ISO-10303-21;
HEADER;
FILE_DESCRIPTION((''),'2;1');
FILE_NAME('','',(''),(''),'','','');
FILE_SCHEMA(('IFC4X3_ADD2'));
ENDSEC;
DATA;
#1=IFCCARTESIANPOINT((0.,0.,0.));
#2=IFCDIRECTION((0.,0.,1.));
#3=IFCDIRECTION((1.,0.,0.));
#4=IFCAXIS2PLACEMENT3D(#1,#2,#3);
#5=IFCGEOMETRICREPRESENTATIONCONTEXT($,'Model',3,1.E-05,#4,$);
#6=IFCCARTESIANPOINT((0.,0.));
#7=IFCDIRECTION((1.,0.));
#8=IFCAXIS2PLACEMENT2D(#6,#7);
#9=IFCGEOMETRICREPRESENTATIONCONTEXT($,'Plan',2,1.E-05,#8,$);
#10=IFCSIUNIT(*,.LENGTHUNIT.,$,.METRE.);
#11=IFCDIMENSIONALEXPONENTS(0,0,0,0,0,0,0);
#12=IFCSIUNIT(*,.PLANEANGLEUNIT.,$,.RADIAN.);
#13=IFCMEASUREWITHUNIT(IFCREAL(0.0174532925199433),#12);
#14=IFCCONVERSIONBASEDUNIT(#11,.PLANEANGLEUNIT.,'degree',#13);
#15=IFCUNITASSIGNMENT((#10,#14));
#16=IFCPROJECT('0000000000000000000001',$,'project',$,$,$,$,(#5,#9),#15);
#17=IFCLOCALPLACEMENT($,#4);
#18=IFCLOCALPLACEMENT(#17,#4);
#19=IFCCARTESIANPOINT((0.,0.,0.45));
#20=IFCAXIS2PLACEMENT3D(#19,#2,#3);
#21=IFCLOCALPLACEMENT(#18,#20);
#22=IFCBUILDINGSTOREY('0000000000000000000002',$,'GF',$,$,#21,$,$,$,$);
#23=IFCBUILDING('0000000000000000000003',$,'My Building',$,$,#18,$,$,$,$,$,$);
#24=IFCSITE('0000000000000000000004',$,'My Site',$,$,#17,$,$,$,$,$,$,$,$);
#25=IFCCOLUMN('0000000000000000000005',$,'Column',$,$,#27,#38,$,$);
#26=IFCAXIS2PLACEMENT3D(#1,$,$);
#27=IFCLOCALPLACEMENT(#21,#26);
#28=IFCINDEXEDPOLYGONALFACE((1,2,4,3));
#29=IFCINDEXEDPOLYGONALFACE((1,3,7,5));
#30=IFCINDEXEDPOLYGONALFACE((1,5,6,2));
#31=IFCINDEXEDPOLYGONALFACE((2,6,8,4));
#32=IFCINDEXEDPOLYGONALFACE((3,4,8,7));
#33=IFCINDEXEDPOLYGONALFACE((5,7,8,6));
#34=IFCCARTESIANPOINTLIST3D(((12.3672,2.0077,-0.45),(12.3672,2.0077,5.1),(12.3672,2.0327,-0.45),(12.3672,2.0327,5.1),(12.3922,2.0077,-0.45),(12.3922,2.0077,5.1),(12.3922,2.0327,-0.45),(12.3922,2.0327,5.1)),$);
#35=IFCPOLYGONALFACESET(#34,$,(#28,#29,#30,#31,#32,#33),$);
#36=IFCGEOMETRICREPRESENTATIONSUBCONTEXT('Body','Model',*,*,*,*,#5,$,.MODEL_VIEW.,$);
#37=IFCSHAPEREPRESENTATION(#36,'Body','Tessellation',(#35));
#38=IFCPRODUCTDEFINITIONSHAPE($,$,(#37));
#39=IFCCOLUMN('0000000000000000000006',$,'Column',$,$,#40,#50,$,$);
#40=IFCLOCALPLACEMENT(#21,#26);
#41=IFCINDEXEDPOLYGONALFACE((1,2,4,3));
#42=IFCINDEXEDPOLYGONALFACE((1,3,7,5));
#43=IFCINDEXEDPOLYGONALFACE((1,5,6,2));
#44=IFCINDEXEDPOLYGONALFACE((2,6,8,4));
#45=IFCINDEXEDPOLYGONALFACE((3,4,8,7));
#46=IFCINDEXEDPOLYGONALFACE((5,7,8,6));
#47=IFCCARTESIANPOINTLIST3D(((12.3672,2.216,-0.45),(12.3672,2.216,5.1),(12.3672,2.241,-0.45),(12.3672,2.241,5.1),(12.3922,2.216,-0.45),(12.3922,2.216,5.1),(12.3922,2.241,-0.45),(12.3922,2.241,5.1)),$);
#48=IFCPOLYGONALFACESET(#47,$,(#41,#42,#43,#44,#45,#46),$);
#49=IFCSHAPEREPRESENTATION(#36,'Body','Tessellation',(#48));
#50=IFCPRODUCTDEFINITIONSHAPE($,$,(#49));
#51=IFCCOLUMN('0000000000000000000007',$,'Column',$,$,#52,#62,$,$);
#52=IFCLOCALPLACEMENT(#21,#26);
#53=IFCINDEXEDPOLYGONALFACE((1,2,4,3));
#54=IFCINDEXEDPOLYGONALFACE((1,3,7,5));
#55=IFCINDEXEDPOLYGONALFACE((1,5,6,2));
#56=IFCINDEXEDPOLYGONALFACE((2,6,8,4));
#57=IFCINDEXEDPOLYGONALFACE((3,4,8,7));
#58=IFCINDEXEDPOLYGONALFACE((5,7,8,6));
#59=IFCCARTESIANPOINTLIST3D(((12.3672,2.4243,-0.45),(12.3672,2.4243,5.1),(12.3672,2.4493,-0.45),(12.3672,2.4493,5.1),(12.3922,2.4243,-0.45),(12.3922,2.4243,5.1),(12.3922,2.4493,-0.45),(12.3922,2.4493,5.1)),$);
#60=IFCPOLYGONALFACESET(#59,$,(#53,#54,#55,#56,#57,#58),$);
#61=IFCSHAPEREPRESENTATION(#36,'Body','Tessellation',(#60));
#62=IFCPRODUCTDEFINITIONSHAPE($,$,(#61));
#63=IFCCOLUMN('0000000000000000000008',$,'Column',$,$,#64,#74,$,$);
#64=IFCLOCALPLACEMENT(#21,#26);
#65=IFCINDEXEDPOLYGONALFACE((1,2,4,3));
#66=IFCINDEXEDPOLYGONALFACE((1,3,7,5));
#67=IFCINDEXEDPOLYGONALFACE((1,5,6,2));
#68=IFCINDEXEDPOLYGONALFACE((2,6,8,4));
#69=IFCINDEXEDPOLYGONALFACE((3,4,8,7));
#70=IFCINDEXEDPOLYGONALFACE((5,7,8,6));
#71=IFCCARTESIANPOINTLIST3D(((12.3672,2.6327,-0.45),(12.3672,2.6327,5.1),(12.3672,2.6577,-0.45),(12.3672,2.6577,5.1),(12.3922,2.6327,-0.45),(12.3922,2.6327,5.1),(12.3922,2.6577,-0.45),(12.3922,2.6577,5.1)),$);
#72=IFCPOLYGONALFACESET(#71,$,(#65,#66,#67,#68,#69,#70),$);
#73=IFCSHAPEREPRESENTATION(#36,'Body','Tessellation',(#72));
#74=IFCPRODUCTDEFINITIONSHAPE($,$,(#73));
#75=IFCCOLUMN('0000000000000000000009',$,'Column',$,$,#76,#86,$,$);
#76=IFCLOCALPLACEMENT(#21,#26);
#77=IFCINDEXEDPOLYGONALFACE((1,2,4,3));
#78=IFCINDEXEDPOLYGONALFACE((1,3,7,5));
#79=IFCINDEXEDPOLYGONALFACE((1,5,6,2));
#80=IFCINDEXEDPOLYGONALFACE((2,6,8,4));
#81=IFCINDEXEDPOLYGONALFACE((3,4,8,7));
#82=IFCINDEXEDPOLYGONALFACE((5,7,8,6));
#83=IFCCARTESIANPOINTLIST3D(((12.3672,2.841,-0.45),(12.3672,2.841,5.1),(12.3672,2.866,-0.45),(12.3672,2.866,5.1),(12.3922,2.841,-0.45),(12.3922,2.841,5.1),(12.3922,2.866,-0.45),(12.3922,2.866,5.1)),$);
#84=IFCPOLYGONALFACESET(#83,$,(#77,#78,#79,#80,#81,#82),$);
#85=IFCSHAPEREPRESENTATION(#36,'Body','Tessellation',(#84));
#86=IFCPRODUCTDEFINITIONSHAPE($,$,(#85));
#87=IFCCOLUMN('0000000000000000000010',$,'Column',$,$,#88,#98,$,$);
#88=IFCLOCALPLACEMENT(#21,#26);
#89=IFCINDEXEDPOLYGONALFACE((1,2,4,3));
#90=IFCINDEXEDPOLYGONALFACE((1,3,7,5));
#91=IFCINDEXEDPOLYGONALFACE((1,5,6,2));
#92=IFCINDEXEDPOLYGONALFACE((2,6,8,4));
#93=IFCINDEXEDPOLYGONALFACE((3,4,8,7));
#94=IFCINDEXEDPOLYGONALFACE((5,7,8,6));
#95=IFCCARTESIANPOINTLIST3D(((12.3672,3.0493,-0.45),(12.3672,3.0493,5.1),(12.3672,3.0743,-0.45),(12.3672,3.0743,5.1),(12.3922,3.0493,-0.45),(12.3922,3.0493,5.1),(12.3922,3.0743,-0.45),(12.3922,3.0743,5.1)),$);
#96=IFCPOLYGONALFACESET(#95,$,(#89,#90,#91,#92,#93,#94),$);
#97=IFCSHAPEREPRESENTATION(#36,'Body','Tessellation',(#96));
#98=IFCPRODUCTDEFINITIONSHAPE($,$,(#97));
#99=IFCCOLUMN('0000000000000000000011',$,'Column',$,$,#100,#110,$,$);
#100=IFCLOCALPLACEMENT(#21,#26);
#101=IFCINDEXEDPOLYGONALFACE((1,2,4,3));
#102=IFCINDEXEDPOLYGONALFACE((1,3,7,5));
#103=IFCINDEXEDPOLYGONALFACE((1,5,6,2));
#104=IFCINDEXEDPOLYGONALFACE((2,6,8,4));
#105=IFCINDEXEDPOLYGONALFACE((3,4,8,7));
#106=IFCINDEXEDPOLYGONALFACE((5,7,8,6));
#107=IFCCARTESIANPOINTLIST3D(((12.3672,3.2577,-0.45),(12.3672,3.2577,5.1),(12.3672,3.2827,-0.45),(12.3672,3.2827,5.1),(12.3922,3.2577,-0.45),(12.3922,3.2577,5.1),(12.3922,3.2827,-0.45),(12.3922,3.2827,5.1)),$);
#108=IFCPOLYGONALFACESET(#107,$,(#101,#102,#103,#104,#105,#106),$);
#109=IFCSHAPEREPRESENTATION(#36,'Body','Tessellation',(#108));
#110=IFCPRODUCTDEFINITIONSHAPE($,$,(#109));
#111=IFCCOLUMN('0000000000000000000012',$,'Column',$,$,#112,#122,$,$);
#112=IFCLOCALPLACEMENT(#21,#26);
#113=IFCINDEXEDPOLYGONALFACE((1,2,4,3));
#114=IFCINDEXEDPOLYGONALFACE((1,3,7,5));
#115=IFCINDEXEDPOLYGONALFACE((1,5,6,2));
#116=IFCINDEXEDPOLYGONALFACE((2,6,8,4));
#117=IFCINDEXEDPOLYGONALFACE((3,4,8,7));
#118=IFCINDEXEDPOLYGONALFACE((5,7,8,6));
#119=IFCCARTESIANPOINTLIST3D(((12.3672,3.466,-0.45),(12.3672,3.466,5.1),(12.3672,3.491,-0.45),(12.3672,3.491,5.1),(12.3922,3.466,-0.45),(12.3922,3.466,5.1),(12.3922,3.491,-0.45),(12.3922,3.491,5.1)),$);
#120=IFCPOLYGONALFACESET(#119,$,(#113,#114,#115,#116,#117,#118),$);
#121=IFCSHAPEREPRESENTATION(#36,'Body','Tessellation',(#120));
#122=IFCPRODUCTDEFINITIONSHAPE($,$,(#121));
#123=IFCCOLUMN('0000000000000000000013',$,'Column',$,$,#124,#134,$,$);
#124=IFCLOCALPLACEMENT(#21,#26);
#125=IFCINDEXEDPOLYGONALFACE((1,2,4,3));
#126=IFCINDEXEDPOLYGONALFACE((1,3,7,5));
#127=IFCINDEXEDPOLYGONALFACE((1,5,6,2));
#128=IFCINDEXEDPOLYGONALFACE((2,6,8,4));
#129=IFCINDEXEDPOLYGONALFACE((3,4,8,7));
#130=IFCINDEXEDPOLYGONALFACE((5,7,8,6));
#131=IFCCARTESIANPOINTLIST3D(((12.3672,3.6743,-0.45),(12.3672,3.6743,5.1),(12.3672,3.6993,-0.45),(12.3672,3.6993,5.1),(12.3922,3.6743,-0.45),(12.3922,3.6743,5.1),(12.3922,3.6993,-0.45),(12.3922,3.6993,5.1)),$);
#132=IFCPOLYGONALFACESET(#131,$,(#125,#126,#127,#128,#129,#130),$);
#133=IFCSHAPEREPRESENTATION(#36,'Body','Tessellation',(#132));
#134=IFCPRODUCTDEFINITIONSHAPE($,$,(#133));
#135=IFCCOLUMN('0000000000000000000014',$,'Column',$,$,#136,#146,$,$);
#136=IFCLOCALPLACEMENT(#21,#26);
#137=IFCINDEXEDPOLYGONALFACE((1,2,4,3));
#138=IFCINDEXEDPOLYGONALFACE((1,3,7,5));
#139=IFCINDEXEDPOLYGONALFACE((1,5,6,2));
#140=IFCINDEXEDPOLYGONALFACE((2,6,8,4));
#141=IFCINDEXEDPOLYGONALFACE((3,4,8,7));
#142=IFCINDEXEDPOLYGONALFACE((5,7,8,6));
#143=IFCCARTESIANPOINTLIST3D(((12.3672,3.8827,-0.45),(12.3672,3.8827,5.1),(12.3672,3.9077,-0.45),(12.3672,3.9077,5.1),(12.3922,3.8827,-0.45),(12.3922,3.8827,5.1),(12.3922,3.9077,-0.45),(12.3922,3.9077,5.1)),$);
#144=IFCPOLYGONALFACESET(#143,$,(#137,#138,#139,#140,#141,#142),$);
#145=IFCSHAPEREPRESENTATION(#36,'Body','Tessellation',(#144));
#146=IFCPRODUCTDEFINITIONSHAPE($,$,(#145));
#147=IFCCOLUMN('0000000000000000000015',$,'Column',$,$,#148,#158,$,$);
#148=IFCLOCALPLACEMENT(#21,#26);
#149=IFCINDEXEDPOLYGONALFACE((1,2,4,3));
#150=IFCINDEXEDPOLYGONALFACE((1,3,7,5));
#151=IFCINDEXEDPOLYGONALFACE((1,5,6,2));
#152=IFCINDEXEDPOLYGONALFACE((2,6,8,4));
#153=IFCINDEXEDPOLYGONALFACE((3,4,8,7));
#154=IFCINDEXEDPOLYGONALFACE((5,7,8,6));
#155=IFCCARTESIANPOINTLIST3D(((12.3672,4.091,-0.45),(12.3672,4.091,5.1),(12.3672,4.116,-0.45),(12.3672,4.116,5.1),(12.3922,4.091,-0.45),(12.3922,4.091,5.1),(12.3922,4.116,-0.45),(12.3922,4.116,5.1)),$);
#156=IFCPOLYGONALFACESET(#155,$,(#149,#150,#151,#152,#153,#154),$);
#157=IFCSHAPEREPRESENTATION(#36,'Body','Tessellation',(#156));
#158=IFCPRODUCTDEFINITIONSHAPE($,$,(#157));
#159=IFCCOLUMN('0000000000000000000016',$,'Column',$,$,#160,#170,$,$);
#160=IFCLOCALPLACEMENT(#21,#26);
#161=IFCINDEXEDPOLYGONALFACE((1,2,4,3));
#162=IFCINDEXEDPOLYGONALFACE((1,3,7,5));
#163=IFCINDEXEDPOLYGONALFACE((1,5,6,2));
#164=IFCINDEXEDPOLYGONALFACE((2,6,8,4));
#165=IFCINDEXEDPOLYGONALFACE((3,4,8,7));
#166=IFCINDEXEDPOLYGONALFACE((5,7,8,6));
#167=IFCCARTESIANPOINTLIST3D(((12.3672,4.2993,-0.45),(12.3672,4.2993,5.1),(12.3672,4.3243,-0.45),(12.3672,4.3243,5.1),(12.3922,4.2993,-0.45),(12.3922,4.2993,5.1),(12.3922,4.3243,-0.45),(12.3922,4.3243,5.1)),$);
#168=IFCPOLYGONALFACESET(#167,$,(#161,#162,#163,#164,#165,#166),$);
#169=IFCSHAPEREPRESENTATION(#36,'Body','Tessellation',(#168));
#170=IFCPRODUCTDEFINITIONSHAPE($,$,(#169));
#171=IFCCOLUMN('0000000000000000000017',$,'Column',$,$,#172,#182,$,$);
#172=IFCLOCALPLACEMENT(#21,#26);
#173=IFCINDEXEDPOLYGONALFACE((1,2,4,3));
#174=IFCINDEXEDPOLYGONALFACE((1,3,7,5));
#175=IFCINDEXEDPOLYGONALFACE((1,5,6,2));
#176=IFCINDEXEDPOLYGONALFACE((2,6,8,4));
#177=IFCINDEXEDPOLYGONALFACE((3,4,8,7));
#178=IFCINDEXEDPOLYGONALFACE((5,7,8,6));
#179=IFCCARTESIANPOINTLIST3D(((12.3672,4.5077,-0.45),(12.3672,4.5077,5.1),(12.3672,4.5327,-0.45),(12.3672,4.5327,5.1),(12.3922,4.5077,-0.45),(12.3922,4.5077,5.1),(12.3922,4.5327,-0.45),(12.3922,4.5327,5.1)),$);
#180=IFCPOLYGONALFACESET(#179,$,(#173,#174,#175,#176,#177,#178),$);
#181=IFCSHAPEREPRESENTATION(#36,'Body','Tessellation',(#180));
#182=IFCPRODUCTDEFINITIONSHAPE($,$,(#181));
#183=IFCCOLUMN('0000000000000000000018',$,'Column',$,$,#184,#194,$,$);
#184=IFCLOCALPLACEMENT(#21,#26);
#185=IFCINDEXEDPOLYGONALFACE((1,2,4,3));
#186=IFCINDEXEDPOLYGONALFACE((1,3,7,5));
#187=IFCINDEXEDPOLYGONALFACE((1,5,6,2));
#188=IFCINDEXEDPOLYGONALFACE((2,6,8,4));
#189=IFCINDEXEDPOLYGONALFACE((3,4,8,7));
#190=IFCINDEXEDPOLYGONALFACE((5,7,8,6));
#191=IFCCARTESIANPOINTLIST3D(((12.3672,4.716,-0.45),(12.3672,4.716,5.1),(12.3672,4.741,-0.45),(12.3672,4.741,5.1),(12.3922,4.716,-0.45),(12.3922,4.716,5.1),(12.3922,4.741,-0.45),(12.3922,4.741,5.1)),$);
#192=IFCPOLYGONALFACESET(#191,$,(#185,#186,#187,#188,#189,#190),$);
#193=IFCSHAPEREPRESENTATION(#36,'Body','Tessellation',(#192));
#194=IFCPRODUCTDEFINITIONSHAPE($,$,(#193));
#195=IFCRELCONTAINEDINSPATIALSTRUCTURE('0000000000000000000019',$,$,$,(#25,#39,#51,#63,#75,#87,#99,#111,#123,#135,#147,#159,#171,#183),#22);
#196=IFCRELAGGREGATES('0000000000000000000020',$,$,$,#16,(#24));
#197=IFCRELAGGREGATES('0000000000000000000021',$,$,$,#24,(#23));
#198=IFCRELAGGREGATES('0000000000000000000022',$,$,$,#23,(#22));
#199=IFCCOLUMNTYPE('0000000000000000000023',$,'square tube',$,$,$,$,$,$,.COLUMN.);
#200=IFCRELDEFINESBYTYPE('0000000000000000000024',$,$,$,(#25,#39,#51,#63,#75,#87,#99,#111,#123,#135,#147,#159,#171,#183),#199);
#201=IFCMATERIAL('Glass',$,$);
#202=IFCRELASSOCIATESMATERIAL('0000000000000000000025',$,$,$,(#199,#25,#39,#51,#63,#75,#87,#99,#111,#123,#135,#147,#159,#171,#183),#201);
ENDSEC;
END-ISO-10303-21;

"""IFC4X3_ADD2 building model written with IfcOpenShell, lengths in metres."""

from ifc_helpers import new_model, entity, si_unit, converted_unit, frame, origin_with_axes, origin_2d_with_axis, place, context, subcontext, project, spatial, rectangle, extrude, material, material_profile, profile_set, profile_usage, type_object, element, save


model = new_model("IFC4X3_ADD2")

# Units and contexts
model_context = context("Model", 3, precision=1e-05, world=origin_with_axes())
plan_context = context("Plan", 2, precision=1e-05, world=origin_2d_with_axis())
body_context = subcontext(model_context, "Body", "Model", "MODEL_VIEW")
ifc_project = project(units=[si_unit("LENGTHUNIT", "METRE"), converted_unit("PLANEANGLEUNIT", "degree", entity("IfcReal", 0.0174532925199433), si_unit("PLANEANGLEUNIT", "RADIAN"), dimensions=[0, 0, 0, 0, 0, 0, 0])], contexts=[model_context, plan_context])

# Site, building, storey
site_placement = place(None, origin_with_axes())
site = spatial("IfcSite", under=ifc_project, at=site_placement, Name="My Site")
building_placement = place(site_placement, origin_with_axes())
building = spatial("IfcBuilding", under=site, at=building_placement, Name="My Building")
storey_placement = place(building_placement, frame((0.0, 0.0, 0.45), z_axis=(0.0, 0.0, 1.0), x_axis=(1.0, 0.0, 0.0)))
storey = spatial("IfcBuildingStorey", under=building, at=storey_placement, Name="GF")

# Columns
ifc_material_1 = material(Name="Glass")
ifc_material_profile = material_profile(ifc_material_1, rectangle(XDim=0.025, YDim=0.025))
ifc_profile_set = profile_set([ifc_material_profile])
ifc_profile_usage_1 = profile_usage(ifc_profile_set, cardinal=5)
column_type = type_object("IfcColumnType", Name="square tube", PredefinedType="COLUMN", material=ifc_profile_set)
column_1_placement = place(storey_placement, frame((12.3797, 2.0202, -0.45), z_axis=(0.0, 0.0, 1.0), x_axis=(0.0, 1.0, 0.0)))
element("IfcColumn", 1, at=column_1_placement, inside=storey, type_object=column_type, material=ifc_profile_usage_1, Name="Column", context=body_context, shape_type="SweptSolid", body=[
    extrude(rectangle(XDim=0.025, YDim=0.025), origin_with_axes(), (0.0, 0.0, 1.0), 5.55),
])
ifc_profile_usage_2 = profile_usage(ifc_profile_set, cardinal=5)
column_2_placement = place(storey_placement, frame((12.3797, 2.2285, -0.45), z_axis=(0.0, 0.0, 1.0), x_axis=(0.0, 1.0, 0.0)))
element("IfcColumn", 2, at=column_2_placement, inside=storey, type_object=column_type, material=ifc_profile_usage_2, Name="Column", context=body_context, shape_type="SweptSolid", body=[
    extrude(rectangle(XDim=0.025, YDim=0.025), origin_with_axes(), (0.0, 0.0, 1.0), 5.55),
])
ifc_profile_usage_3 = profile_usage(ifc_profile_set, cardinal=5)
column_3_placement = place(storey_placement, frame((12.3797, 2.4368, -0.45), z_axis=(0.0, 0.0, 1.0), x_axis=(0.0, 1.0, 0.0)))
element("IfcColumn", 3, at=column_3_placement, inside=storey, type_object=column_type, material=ifc_profile_usage_3, Name="Column", context=body_context, shape_type="SweptSolid", body=[
    extrude(rectangle(XDim=0.025, YDim=0.025), origin_with_axes(), (0.0, 0.0, 1.0), 5.55),
])
ifc_profile_usage_4 = profile_usage(ifc_profile_set, cardinal=5)
column_4_placement = place(storey_placement, frame((12.3797, 2.6452, -0.45), z_axis=(0.0, 0.0, 1.0), x_axis=(0.0, 1.0, 0.0)))
element("IfcColumn", 4, at=column_4_placement, inside=storey, type_object=column_type, material=ifc_profile_usage_4, Name="Column", context=body_context, shape_type="SweptSolid", body=[
    extrude(rectangle(XDim=0.025, YDim=0.025), origin_with_axes(), (0.0, 0.0, 1.0), 5.55),
])
ifc_profile_usage_5 = profile_usage(ifc_profile_set, cardinal=5)
column_5_placement = place(storey_placement, frame((12.3797, 2.8535, -0.45), z_axis=(0.0, 0.0, 1.0), x_axis=(0.0, 1.0, 0.0)))
element("IfcColumn", 5, at=column_5_placement, inside=storey, type_object=column_type, material=ifc_profile_usage_5, Name="Column", context=body_context, shape_type="SweptSolid", body=[
    extrude(rectangle(XDim=0.025, YDim=0.025), origin_with_axes(), (0.0, 0.0, 1.0), 5.55),
])
ifc_profile_usage_6 = profile_usage(ifc_profile_set, cardinal=5)
column_6_placement = place(storey_placement, frame((12.3797, 3.0618, -0.45), z_axis=(0.0, 0.0, 1.0), x_axis=(0.0, 1.0, 0.0)))
element("IfcColumn", 6, at=column_6_placement, inside=storey, type_object=column_type, material=ifc_profile_usage_6, Name="Column", context=body_context, shape_type="SweptSolid", body=[
    extrude(rectangle(XDim=0.025, YDim=0.025), origin_with_axes(), (0.0, 0.0, 1.0), 5.55),
])
ifc_profile_usage_7 = profile_usage(ifc_profile_set, cardinal=5)
column_7_placement = place(storey_placement, frame((12.3797, 3.2702, -0.45), z_axis=(0.0, 0.0, 1.0), x_axis=(0.0, 1.0, 0.0)))
element("IfcColumn", 7, at=column_7_placement, inside=storey, type_object=column_type, material=ifc_profile_usage_7, Name="Column", context=body_context, shape_type="SweptSolid", body=[
    extrude(rectangle(XDim=0.025, YDim=0.025), origin_with_axes(), (0.0, 0.0, 1.0), 5.55),
])
ifc_profile_usage_8 = profile_usage(ifc_profile_set, cardinal=5)
column_8_placement = place(storey_placement, frame((12.3797, 3.4785, -0.45), z_axis=(0.0, 0.0, 1.0), x_axis=(0.0, 1.0, 0.0)))
element("IfcColumn", 8, at=column_8_placement, inside=storey, type_object=column_type, material=ifc_profile_usage_8, Name="Column", context=body_context, shape_type="SweptSolid", body=[
    extrude(rectangle(XDim=0.025, YDim=0.025), origin_with_axes(), (0.0, 0.0, 1.0), 5.55),
])
ifc_profile_usage_9 = profile_usage(ifc_profile_set, cardinal=5)
column_9_placement = place(storey_placement, frame((12.3797, 3.6868, -0.45), z_axis=(0.0, 0.0, 1.0), x_axis=(0.0, 1.0, 0.0)))
element("IfcColumn", 9, at=column_9_placement, inside=storey, type_object=column_type, material=ifc_profile_usage_9, Name="Column", context=body_context, shape_type="SweptSolid", body=[
    extrude(rectangle(XDim=0.025, YDim=0.025), origin_with_axes(), (0.0, 0.0, 1.0), 5.55),
])
ifc_profile_usage_10 = profile_usage(ifc_profile_set, cardinal=5)
column_10_placement = place(storey_placement, frame((12.3797, 3.8952, -0.45), z_axis=(0.0, 0.0, 1.0), x_axis=(0.0, 1.0, 0.0)))
element("IfcColumn", 10, at=column_10_placement, inside=storey, type_object=column_type, material=ifc_profile_usage_10, Name="Column", context=body_context, shape_type="SweptSolid", body=[
    extrude(rectangle(XDim=0.025, YDim=0.025), origin_with_axes(), (0.0, 0.0, 1.0), 5.55),
])
ifc_profile_usage_11 = profile_usage(ifc_profile_set, cardinal=5)
column_11_placement = place(storey_placement, frame((12.3797, 4.1035, -0.45), z_axis=(0.0, 0.0, 1.0), x_axis=(0.0, 1.0, 0.0)))
element("IfcColumn", 11, at=column_11_placement, inside=storey, type_object=column_type, material=ifc_profile_usage_11, Name="Column", context=body_context, shape_type="SweptSolid", body=[
    extrude(rectangle(XDim=0.025, YDim=0.025), origin_with_axes(), (0.0, 0.0, 1.0), 5.55),
])
ifc_profile_usage_12 = profile_usage(ifc_profile_set, cardinal=5)
column_12_placement = place(storey_placement, frame((12.3797, 4.3118, -0.45), z_axis=(0.0, 0.0, 1.0), x_axis=(0.0, 1.0, 0.0)))
element("IfcColumn", 12, at=column_12_placement, inside=storey, type_object=column_type, material=ifc_profile_usage_12, Name="Column", context=body_context, shape_type="SweptSolid", body=[
    extrude(rectangle(XDim=0.025, YDim=0.025), origin_with_axes(), (0.0, 0.0, 1.0), 5.55),
])
ifc_profile_usage_13 = profile_usage(ifc_profile_set, cardinal=5)
column_13_placement = place(storey_placement, frame((12.3797, 4.5202, -0.45), z_axis=(0.0, 0.0, 1.0), x_axis=(0.0, 1.0, 0.0)))
element("IfcColumn", 13, at=column_13_placement, inside=storey, type_object=column_type, material=ifc_profile_usage_13, Name="Column", context=body_context, shape_type="SweptSolid", body=[
    extrude(rectangle(XDim=0.025, YDim=0.025), origin_with_axes(), (0.0, 0.0, 1.0), 5.55),
])
ifc_profile_usage_14 = profile_usage(ifc_profile_set, cardinal=5)
column_14_placement = place(storey_placement, frame((12.3797, 4.7285, -0.45), z_axis=(0.0, 0.0, 1.0), x_axis=(0.0, 1.0, 0.0)))
element("IfcColumn", 14, at=column_14_placement, inside=storey, type_object=column_type, material=ifc_profile_usage_14, Name="Column", context=body_context, shape_type="SweptSolid", body=[
    extrude(rectangle(XDim=0.025, YDim=0.025), origin_with_axes(), (0.0, 0.0, 1.0), 5.55),
])

save(model, "model.ifc")
